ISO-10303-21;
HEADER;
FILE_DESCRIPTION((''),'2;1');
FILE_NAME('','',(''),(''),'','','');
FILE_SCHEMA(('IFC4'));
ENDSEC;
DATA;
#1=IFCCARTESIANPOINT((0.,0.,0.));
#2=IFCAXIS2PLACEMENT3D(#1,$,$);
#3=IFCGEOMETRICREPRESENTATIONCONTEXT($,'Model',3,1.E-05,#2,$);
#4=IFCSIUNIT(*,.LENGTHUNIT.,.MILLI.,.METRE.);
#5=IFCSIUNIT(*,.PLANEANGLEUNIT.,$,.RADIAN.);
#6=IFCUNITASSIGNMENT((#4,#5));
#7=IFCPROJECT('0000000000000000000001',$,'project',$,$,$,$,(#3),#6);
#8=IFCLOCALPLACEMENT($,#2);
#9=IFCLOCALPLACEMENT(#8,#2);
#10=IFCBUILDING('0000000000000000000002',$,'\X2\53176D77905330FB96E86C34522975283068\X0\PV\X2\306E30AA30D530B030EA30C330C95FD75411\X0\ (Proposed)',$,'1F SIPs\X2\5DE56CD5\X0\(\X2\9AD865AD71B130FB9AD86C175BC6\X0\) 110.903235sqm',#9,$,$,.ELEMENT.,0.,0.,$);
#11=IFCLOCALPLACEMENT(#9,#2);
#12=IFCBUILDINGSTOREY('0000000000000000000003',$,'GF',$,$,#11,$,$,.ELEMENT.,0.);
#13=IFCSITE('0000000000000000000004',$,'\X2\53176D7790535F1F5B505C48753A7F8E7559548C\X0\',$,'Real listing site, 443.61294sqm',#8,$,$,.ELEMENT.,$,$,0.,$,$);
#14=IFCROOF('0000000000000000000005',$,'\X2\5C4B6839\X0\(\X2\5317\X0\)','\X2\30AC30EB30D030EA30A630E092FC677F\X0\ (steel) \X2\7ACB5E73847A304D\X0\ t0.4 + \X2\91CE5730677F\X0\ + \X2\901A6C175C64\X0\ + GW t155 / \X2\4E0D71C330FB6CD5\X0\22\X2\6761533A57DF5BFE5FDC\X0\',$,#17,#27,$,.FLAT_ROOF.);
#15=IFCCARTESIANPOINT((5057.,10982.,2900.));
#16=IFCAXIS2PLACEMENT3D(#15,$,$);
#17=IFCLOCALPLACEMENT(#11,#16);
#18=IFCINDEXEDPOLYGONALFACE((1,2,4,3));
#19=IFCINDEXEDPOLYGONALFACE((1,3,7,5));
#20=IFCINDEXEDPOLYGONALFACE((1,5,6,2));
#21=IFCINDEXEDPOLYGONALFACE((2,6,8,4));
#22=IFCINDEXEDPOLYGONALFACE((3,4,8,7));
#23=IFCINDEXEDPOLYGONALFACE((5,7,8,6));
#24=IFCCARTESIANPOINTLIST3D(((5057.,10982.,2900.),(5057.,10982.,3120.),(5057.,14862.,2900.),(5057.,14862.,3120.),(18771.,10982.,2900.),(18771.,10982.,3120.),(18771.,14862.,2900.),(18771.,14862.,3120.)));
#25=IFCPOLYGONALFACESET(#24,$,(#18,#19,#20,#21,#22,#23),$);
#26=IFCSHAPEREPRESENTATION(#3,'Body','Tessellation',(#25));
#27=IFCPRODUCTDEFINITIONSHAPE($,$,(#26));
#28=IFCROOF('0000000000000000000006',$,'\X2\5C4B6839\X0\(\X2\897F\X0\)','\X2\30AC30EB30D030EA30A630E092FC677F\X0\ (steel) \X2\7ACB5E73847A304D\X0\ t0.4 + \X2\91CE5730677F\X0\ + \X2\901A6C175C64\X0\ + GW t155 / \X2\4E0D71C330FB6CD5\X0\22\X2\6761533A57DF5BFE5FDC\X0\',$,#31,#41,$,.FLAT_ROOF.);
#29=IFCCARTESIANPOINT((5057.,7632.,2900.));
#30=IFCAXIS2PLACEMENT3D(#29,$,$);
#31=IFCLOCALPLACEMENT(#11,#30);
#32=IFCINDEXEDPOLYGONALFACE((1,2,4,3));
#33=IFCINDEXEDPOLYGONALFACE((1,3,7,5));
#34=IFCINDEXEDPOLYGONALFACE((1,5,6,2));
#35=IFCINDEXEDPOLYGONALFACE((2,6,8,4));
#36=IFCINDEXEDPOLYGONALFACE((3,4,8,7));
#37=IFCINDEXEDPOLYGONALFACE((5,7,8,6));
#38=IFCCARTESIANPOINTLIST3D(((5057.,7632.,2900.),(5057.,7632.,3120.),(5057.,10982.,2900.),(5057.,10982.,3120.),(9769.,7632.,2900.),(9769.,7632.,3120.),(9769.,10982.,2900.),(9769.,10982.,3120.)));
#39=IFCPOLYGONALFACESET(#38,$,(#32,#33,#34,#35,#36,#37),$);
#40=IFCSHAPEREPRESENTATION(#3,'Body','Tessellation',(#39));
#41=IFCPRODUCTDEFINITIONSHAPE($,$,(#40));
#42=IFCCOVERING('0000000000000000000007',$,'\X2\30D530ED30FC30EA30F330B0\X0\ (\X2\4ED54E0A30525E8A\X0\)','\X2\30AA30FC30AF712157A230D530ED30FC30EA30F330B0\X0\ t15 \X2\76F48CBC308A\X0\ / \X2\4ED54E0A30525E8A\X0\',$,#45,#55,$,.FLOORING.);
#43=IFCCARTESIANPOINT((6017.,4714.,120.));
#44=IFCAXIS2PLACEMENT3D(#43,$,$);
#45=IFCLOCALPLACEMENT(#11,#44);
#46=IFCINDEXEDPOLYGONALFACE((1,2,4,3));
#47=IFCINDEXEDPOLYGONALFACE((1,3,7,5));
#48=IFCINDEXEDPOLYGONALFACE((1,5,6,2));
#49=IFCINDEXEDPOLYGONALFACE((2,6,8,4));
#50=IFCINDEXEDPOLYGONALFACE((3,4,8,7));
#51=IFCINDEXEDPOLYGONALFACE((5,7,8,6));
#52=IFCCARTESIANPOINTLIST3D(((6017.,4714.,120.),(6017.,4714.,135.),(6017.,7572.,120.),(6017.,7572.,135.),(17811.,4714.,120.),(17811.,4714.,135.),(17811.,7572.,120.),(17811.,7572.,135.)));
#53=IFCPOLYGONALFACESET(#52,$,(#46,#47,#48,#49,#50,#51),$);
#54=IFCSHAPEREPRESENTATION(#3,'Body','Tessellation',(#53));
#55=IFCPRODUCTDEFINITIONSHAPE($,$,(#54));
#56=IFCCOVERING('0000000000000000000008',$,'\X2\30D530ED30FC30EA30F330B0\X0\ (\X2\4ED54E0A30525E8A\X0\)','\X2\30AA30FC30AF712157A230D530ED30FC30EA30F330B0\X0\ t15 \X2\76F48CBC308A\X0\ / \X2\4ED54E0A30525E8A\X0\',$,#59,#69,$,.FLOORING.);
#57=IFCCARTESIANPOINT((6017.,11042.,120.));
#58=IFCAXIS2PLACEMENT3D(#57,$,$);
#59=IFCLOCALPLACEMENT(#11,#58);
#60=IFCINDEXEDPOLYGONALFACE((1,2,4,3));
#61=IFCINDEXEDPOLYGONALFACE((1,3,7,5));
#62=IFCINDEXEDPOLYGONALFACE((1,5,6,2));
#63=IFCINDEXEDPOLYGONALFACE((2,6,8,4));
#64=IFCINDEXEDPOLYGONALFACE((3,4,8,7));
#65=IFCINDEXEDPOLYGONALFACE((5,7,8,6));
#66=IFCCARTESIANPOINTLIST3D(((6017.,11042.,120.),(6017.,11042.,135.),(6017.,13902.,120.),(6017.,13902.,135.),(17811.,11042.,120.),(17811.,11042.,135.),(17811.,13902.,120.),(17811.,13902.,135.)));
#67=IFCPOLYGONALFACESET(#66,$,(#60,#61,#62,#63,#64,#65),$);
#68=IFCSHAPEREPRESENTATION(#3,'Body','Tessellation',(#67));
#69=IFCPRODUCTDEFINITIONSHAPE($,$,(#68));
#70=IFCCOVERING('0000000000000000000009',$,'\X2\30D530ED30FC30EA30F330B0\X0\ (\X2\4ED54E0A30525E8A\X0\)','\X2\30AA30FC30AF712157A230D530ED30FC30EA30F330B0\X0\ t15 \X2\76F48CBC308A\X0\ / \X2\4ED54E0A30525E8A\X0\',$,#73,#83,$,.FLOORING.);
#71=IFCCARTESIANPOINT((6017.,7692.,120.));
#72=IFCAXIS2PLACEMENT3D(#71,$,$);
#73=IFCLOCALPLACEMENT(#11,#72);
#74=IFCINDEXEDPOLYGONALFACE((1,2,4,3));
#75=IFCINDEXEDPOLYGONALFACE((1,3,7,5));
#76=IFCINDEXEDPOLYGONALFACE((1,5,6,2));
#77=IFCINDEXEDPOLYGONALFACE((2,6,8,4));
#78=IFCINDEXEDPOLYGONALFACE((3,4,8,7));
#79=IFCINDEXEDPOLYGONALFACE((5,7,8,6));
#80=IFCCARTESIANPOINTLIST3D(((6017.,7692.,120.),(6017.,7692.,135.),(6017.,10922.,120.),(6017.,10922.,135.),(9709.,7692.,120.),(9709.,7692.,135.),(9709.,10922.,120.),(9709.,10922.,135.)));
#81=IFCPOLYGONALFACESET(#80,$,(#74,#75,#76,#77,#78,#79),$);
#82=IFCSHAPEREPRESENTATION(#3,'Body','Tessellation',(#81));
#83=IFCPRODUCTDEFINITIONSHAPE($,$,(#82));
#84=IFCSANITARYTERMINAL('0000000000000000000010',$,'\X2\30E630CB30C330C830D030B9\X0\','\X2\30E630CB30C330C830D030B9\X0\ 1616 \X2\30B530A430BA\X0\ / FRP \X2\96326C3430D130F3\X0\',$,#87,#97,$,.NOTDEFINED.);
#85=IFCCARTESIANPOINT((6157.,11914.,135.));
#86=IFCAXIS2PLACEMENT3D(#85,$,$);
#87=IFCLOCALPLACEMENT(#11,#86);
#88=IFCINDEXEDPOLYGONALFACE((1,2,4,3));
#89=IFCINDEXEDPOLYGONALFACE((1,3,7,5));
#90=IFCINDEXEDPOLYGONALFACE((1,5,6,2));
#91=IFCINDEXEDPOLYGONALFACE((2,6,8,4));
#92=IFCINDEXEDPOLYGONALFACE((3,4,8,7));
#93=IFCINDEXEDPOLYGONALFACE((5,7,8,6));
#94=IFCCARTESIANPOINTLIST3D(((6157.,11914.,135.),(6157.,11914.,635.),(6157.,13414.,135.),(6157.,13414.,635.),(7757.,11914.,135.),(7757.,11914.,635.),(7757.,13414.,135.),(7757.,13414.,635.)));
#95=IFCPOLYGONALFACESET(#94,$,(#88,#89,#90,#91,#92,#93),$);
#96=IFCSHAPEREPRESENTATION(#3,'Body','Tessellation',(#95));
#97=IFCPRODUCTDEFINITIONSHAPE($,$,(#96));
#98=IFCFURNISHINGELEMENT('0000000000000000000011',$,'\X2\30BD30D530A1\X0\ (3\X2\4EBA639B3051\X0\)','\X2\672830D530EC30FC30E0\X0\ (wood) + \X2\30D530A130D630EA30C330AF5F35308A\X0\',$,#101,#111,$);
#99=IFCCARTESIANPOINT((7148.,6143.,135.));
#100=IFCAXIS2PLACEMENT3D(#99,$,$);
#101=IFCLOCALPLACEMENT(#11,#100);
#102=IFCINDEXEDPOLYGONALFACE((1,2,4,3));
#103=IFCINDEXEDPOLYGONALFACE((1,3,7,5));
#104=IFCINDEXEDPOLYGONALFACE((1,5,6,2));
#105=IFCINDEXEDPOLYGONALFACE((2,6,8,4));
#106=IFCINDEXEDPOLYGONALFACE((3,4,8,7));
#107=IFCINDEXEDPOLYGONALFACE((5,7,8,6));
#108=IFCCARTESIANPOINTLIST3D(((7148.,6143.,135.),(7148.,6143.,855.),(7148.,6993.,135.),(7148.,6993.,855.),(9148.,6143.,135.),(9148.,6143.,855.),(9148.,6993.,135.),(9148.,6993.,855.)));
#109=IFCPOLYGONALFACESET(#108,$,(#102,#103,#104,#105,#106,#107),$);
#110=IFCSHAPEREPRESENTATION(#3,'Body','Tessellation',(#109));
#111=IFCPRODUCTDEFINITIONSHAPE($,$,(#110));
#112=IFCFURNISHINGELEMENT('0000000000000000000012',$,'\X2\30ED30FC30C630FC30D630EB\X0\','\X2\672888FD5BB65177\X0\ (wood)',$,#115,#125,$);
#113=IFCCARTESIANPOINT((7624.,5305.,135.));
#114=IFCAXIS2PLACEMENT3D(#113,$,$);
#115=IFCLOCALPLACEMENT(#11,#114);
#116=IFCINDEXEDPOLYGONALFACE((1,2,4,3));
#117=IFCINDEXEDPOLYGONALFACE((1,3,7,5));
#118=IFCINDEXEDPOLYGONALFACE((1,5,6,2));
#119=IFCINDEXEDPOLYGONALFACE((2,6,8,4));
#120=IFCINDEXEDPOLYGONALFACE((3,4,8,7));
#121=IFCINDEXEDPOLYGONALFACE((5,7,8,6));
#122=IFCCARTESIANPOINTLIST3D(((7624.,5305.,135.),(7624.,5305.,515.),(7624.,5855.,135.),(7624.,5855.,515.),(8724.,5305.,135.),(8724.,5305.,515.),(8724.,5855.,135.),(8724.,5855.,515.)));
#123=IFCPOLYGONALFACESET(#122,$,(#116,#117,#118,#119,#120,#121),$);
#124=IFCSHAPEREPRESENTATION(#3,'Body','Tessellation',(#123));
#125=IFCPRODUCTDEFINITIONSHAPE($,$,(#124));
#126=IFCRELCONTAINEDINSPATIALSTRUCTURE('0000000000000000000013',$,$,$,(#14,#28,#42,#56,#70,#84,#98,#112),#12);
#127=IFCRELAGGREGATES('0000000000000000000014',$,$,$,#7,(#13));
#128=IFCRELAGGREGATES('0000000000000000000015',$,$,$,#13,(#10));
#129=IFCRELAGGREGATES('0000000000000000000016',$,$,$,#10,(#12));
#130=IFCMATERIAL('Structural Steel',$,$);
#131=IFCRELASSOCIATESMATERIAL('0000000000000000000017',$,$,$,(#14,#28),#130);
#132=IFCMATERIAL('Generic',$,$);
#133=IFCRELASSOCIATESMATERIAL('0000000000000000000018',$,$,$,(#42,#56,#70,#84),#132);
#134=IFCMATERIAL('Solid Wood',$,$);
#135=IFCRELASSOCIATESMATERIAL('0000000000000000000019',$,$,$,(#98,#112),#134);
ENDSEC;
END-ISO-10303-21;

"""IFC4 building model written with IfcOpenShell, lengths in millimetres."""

from ifc_helpers import new_model, si_unit, frame, frame_2d, origin, place, context, project, spatial, rectangle, extrude, material, element, save


model = new_model("IFC4")

# Units and contexts
model_context = context("Model", 3, precision=1e-05, world=origin())
ifc_project = project(units=[si_unit("LENGTHUNIT", "METRE", prefix="MILLI"), si_unit("PLANEANGLEUNIT", "RADIAN")], contexts=[model_context])

# Site, building, storey
site_placement = place(None, origin())
site = spatial("IfcSite", under=ifc_project, at=site_placement, Name="北海道弟子屈町美留和", ObjectType="Real listing site, 443.61294sqm", CompositionType="ELEMENT", RefElevation=0.0)
building_placement = place(site_placement, origin())
building = spatial("IfcBuilding", under=site, at=building_placement, Name="北海道・雨水利用とPVのオフグリッド志向 (Proposed)", ObjectType="1F SIPs工法(高断熱・高気密) 110.903235sqm", CompositionType="ELEMENT", ElevationOfRefHeight=0.0, ElevationOfTerrain=0.0)
storey_placement = place(building_placement, origin())
storey = spatial("IfcBuildingStorey", under=building, at=storey_placement, Name="GF", CompositionType="ELEMENT", Elevation=0.0)

# Shared definitions
ifc_material_1 = material(Name="Solid Wood")

# Roofs
ifc_material_2 = material(Name="Structural Steel")
roof_1_placement = place(storey_placement, frame((5057.0, 10982.0, 2900.0)))
element("IfcRoof", 1, at=roof_1_placement, inside=storey, material=ifc_material_2, Name="屋根(北)", Description="ガルバリウム鋼板 (steel) 立平葺き t0.4 + 野地板 + 通気層 + GW t155 / 不燃・法22条区域対応", PredefinedType="FLAT_ROOF", context=model_context, shape_type="SweptSolid", body=[
    extrude(rectangle(XDim=13714.0, YDim=3880.0, at=frame_2d((6857.0, 1940.0))), frame((5057.0, 10982.0, 2900.0)), (0.0, 0.0, 1.0), 220.0),
])
roof_2_placement = place(storey_placement, frame((5057.0, 7632.0, 2900.0)))
element("IfcRoof", 2, at=roof_2_placement, inside=storey, material=ifc_material_2, Name="屋根(西)", Description="ガルバリウム鋼板 (steel) 立平葺き t0.4 + 野地板 + 通気層 + GW t155 / 不燃・法22条区域対応", PredefinedType="FLAT_ROOF", context=model_context, shape_type="SweptSolid", body=[
    extrude(rectangle(XDim=4712.0, YDim=3350.0, at=frame_2d((2356.0, 1675.0))), frame((5057.0, 7632.0, 2900.0)), (0.0, 0.0, 1.0), 220.0),
])

# Coverings
ifc_material_3 = material(Name="Generic")
covering_1_placement = place(storey_placement, frame((6017.0, 4714.0, 120.0)))
element("IfcCovering", 3, at=covering_1_placement, inside=storey, material=ifc_material_3, Name="フローリング (仕上げ床)", Description="オーク無垢フローリング t15 直貼り / 仕上げ床", PredefinedType="FLOORING", context=model_context, shape_type="SweptSolid", body=[
    extrude(rectangle(XDim=11794.0, YDim=2858.0, at=frame_2d((5897.0, 1429.0))), frame((6017.0, 4714.0, 120.0)), (0.0, 0.0, 1.0), 15.0),
])
covering_2_placement = place(storey_placement, frame((6017.0, 11042.0, 120.0)))
element("IfcCovering", 4, at=covering_2_placement, inside=storey, material=ifc_material_3, Name="フローリング (仕上げ床)", Description="オーク無垢フローリング t15 直貼り / 仕上げ床", PredefinedType="FLOORING", context=model_context, shape_type="SweptSolid", body=[
    extrude(rectangle(XDim=11794.0, YDim=2860.0, at=frame_2d((5897.0, 1430.0))), frame((6017.0, 11042.0, 120.0)), (0.0, 0.0, 1.0), 15.0),
])
covering_3_placement = place(storey_placement, frame((6017.0, 7692.0, 120.0)))
element("IfcCovering", 5, at=covering_3_placement, inside=storey, material=ifc_material_3, Name="フローリング (仕上げ床)", Description="オーク無垢フローリング t15 直貼り / 仕上げ床", PredefinedType="FLOORING", context=model_context, shape_type="SweptSolid", body=[
    extrude(rectangle(XDim=3692.0, YDim=3230.0, at=frame_2d((1846.0, 1615.0))), frame((6017.0, 7692.0, 120.0)), (0.0, 0.0, 1.0), 15.0),
])

# Sanitary terminal
sanitary_terminal_placement = place(storey_placement, frame((6157.0, 11914.0, 135.0)))
element("IfcSanitaryTerminal", 6, at=sanitary_terminal_placement, inside=storey, material=ifc_material_3, Name="ユニットバス", Description="ユニットバス 1616 サイズ / FRP 防水パン", PredefinedType="NOTDEFINED", context=model_context, shape_type="SweptSolid", body=[
    extrude(rectangle(XDim=1600.0, YDim=1500.0, at=frame_2d((800.0, 750.0))), frame((6157.0, 11914.0, 135.0)), (0.0, 0.0, 1.0), 500.0),
])

# Furnishing elements
furnishing_1_placement = place(storey_placement, frame((7148.0, 6143.0, 135.0)))
element("IfcFurnishingElement", 7, at=furnishing_1_placement, inside=storey, material=ifc_material_1, Name="ソファ (3人掛け)", Description="木フレーム (wood) + ファブリック張り", context=model_context, shape_type="SweptSolid", body=[
    extrude(rectangle(XDim=2000.0, YDim=850.0, at=frame_2d((1000.0, 425.0))), frame((7148.0, 6143.0, 135.0)), (0.0, 0.0, 1.0), 720.0),
])
furnishing_2_placement = place(storey_placement, frame((7624.0, 5305.0, 135.0)))
element("IfcFurnishingElement", 8, at=furnishing_2_placement, inside=storey, material=ifc_material_1, Name="ローテーブル", Description="木製家具 (wood)", context=model_context, shape_type="SweptSolid", body=[
    extrude(rectangle(XDim=1100.0, YDim=550.0, at=frame_2d((550.0, 275.0))), frame((7624.0, 5305.0, 135.0)), (0.0, 0.0, 1.0), 380.0),
])

save(model, "model.ifc")
